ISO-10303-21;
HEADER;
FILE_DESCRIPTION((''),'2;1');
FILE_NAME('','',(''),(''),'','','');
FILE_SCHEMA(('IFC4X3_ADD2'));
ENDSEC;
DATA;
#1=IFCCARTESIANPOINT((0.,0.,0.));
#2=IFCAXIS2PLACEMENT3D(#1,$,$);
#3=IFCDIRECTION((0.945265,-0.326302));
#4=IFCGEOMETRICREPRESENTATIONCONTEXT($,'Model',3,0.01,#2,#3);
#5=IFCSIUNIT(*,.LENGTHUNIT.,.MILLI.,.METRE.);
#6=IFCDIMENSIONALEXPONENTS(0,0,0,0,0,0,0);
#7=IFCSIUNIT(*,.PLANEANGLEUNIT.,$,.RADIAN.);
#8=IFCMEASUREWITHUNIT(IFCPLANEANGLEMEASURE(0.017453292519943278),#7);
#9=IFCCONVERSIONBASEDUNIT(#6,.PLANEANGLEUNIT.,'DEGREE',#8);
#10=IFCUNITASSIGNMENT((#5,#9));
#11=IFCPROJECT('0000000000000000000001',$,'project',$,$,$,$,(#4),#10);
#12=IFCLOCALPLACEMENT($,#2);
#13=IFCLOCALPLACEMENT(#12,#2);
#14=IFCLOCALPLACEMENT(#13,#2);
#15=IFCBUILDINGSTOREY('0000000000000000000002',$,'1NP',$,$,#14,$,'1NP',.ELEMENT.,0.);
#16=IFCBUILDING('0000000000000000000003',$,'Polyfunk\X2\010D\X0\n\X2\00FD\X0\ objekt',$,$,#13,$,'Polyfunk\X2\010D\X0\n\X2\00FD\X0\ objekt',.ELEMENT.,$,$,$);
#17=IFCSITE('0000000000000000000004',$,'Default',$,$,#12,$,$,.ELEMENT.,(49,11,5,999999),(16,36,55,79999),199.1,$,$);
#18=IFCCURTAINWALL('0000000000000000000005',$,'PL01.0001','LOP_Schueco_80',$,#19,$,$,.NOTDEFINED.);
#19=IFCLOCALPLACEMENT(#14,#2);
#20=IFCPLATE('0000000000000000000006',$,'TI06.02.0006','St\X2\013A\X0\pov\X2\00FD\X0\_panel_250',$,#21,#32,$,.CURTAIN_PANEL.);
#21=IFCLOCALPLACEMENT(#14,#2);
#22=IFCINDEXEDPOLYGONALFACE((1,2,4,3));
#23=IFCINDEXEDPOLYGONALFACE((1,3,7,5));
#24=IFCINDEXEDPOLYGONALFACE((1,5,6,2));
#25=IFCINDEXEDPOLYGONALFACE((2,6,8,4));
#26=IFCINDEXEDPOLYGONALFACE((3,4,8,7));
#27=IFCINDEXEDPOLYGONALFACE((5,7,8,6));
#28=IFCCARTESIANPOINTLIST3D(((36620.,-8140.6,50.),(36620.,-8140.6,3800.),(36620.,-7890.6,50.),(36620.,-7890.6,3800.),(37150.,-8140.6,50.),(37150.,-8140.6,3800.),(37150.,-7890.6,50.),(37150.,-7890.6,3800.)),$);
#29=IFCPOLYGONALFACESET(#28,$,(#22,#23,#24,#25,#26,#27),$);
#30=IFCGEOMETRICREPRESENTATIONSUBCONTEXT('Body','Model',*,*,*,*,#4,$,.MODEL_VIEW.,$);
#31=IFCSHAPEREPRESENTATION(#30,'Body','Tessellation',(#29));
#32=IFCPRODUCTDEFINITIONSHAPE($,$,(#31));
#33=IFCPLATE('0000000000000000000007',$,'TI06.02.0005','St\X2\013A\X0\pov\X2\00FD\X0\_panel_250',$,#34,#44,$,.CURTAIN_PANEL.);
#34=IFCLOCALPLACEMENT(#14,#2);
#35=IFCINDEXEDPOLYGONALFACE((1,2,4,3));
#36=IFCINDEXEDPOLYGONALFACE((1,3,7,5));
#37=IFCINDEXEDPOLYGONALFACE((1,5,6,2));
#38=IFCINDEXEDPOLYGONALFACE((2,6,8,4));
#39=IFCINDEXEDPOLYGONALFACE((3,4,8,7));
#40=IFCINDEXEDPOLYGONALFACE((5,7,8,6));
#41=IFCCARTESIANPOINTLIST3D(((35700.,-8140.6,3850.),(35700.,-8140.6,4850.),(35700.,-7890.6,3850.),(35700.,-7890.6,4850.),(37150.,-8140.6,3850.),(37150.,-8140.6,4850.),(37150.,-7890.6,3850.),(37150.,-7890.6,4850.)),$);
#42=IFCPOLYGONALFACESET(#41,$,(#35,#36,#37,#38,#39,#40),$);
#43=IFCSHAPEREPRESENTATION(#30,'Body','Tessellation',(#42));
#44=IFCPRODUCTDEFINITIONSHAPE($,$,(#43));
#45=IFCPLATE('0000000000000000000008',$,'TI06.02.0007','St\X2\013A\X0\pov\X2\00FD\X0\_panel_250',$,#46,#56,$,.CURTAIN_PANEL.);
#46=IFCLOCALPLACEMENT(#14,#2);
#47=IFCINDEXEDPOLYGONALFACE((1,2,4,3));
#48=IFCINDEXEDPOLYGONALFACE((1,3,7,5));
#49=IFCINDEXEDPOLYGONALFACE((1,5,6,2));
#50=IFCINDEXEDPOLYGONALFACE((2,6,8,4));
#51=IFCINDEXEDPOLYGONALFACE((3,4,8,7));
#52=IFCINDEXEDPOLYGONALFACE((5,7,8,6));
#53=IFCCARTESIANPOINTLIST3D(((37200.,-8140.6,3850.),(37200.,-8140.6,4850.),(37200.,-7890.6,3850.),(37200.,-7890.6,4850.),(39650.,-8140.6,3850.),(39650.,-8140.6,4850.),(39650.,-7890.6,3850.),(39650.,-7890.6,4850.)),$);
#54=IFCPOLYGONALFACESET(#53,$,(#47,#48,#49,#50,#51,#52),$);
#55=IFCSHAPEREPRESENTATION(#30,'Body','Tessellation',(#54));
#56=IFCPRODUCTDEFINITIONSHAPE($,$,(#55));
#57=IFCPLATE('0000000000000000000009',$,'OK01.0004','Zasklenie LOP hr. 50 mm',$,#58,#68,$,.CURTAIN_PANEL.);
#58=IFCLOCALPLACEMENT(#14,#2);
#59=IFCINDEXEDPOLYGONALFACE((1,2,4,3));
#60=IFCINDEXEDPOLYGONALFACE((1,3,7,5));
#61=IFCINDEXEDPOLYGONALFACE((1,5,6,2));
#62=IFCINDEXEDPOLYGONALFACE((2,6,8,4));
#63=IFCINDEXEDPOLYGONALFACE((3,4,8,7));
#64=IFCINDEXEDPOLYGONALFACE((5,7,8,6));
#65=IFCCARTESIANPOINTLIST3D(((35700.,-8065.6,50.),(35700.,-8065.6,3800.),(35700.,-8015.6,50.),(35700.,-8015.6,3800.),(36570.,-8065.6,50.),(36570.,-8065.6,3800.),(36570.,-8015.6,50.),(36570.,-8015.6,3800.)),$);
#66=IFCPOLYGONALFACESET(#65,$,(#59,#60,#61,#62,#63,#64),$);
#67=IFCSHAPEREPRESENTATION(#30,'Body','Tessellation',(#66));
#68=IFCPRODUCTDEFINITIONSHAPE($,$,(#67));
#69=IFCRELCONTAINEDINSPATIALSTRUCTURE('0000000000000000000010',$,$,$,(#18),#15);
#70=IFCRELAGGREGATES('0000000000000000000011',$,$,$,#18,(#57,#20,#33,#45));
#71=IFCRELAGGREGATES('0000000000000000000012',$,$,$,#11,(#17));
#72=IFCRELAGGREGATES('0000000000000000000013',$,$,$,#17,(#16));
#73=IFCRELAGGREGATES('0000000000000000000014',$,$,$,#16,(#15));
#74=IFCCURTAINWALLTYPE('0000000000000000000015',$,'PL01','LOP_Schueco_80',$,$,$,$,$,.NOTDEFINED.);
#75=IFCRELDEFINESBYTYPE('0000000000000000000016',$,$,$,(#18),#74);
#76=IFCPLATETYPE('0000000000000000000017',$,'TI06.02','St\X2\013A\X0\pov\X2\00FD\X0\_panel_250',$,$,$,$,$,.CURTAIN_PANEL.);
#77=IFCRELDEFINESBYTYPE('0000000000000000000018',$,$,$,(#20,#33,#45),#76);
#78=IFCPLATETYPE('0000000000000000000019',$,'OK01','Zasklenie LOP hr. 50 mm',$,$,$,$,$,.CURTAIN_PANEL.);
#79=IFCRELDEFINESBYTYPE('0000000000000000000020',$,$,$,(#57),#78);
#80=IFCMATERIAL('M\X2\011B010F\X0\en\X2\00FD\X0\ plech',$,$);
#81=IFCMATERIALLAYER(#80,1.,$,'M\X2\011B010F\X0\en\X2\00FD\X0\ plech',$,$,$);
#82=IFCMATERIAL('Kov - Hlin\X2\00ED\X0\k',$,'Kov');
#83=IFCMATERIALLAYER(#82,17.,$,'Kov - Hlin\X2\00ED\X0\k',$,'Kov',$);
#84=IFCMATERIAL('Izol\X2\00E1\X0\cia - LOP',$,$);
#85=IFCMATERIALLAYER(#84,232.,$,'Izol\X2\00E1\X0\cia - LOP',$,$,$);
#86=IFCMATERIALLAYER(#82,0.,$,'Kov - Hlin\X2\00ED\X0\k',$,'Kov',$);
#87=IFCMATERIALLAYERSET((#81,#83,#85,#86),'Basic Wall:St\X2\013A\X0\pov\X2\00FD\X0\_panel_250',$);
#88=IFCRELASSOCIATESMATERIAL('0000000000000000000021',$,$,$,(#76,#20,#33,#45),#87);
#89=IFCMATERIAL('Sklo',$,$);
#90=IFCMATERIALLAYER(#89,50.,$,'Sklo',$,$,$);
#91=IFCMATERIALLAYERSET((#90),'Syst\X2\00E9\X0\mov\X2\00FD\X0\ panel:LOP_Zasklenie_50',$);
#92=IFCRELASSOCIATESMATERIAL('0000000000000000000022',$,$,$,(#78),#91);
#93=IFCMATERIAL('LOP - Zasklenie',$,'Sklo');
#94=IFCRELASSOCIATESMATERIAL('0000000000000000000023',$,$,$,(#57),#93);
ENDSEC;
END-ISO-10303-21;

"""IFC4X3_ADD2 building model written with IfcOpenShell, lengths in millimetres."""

from ifc_helpers import new_model, entity, si_unit, converted_unit, direction, frame, frame_2d, origin, place, context, subcontext, project, spatial, rectangle, extrude, source, transform, mapped, material, layer, layer_set, layer_usage, type_object, type_shapes, element, aggregate, save


model = new_model("IFC4X3_ADD2")

# Units and contexts
model_context = context("Model", 3, precision=0.01, world=origin(), true_north=direction((0.945265, -0.326302)))
body_context = subcontext(model_context, "Body", "Model", "MODEL_VIEW")
ifc_project = project(units=[si_unit("LENGTHUNIT", "METRE", prefix="MILLI"), converted_unit("PLANEANGLEUNIT", "DEGREE", entity("IfcPlaneAngleMeasure", 0.017453292519943278), si_unit("PLANEANGLEUNIT", "RADIAN"), dimensions=[0, 0, 0, 0, 0, 0, 0])], contexts=[model_context])

# Site, building, storey
site_placement = place(None, origin())
site = spatial("IfcSite", under=ifc_project, at=site_placement, Name="Default", CompositionType="ELEMENT", RefLatitude=(49, 11, 5, 999999), RefLongitude=(16, 36, 55, 79999), RefElevation=199.1)
building_placement = place(site_placement, origin())
building = spatial("IfcBuilding", under=site, at=building_placement, Name="Polyfunkčný objekt", LongName="Polyfunkčný objekt", CompositionType="ELEMENT")
storey_placement = place(building_placement, origin())
storey = spatial("IfcBuildingStorey", under=building, at=storey_placement, Name="1NP", LongName="1NP", CompositionType="ELEMENT", Elevation=0.0)

# Curtain wall, plates
curtain_wall_type = type_object("IfcCurtainWallType", Name="PL01", Description="LOP_Schueco_80", PredefinedType="NOTDEFINED")
curtain_wall_placement = place(storey_placement, origin())
curtain_wall = element("IfcCurtainWall", 1, at=curtain_wall_placement, inside=storey, type_object=curtain_wall_type, Name="PL01.0001", Description="LOP_Schueco_80", PredefinedType="NOTDEFINED")
ifc_material_1 = material(Name="Měďený plech")
ifc_layer_1 = layer(ifc_material_1, 1.0, Name="Měďený plech")
ifc_material_2 = material(Name="Kov - Hliník", Category="Kov")
ifc_layer_2 = layer(ifc_material_2, 17.0, Name="Kov - Hliník", Category="Kov")
ifc_material_3 = material(Name="Izolácia - LOP")
ifc_layer_3 = layer(ifc_material_3, 232.0, Name="Izolácia - LOP")
ifc_layer_4 = layer(ifc_material_2, 0.0, Name="Kov - Hliník", Category="Kov")
ifc_layer_set_1 = layer_set([ifc_layer_1, ifc_layer_2, ifc_layer_3, ifc_layer_4], Name="Basic Wall:Stĺpový_panel_250")
ifc_layer_usage_1 = layer_usage(ifc_layer_set_1, "AXIS2", "POSITIVE", -125.0)
plate_type_1 = type_object("IfcPlateType", Name="TI06.02", Description="Stĺpový_panel_250", PredefinedType="CURTAIN_PANEL", material=ifc_layer_set_1)
plate_1_placement = place(storey_placement, frame((36620.0, -8015.6, 50.0)))
plate_1 = element("IfcPlate", 2, at=plate_1_placement, type_object=plate_type_1, material=ifc_layer_usage_1, Name="TI06.02.0006", Description="Stĺpový_panel_250", PredefinedType="CURTAIN_PANEL", context=body_context, shape_type="SweptSolid", body=[
    extrude(rectangle(XDim=250.0, YDim=530.0, at=frame_2d((0.0, 0.0), x_axis=(1.0, 0.0))), frame((265.0, 0.0, 0.0), z_axis=(0.0, 0.0, 1.0), x_axis=(0.0, 1.0, 0.0)), (0.0, 0.0, 1.0), 3750.0),
])
ifc_layer_usage_2 = layer_usage(ifc_layer_set_1, "AXIS2", "POSITIVE", -125.0)
plate_2_placement = place(storey_placement, frame((35700.0, -8015.6, 3850.0)))
plate_2 = element("IfcPlate", 3, at=plate_2_placement, type_object=plate_type_1, material=ifc_layer_usage_2, Name="TI06.02.0005", Description="Stĺpový_panel_250", PredefinedType="CURTAIN_PANEL", context=body_context, shape_type="SweptSolid", body=[
    extrude(rectangle(XDim=250.0, YDim=1450.0, at=frame_2d((0.0, 0.0), x_axis=(1.0, 0.0))), frame((725.0, 0.0, 0.0), z_axis=(0.0, 0.0, 1.0), x_axis=(0.0, 1.0, 0.0)), (0.0, 0.0, 1.0), 1000.0),
])
ifc_layer_usage_3 = layer_usage(ifc_layer_set_1, "AXIS2", "POSITIVE", -125.0)
plate_3_placement = place(storey_placement, frame((37200.0, -8015.6, 3850.0)))
plate_3 = element("IfcPlate", 4, at=plate_3_placement, type_object=plate_type_1, material=ifc_layer_usage_3, Name="TI06.02.0007", Description="Stĺpový_panel_250", PredefinedType="CURTAIN_PANEL", context=body_context, shape_type="SweptSolid", body=[
    extrude(rectangle(XDim=250.0, YDim=2450.0, at=frame_2d((0.0, 0.0), x_axis=(1.0, 0.0))), frame((1225.0, 0.0, 0.0), z_axis=(0.0, 0.0, 1.0), x_axis=(0.0, 1.0, 0.0)), (0.0, 0.0, 1.0), 1000.0),
])
ifc_material_4 = material(Name="LOP - Zasklenie", Category="Sklo")
ifc_material_5 = material(Name="Sklo")
ifc_layer_5 = layer(ifc_material_5, 50.0, Name="Sklo")
ifc_layer_set_2 = layer_set([ifc_layer_5], Name="Systémový panel:LOP_Zasklenie_50")
plate_type_2 = type_object("IfcPlateType", Name="OK01", Description="Zasklenie LOP hr. 50 mm", PredefinedType="CURTAIN_PANEL", material=ifc_layer_set_2)
shared_shape_1 = source(origin(), body_context, "Body", "SweptSolid", [
    extrude(rectangle(XDim=3750.0, YDim=870.0, at=frame_2d((-331.2, 0.0), x_axis=(1.0, 0.0))), frame((0.0, -50.0, 2206.2), z_axis=(0.0, 1.0, 0.0), x_axis=(0.0, 0.0, 1.0)), (0.0, 0.0, 1.0), 50.0),
])
type_shapes(plate_type_2, [shared_shape_1])
plate_4_placement = place(curtain_wall_placement, frame((36135.0, -8015.6, 50.0)))
plate_4 = element("IfcPlate", 5, at=plate_4_placement, type_object=plate_type_2, material=ifc_material_4, Name="OK01.0004", Description="Zasklenie LOP hr. 50 mm", PredefinedType="CURTAIN_PANEL", context=body_context, shape_type="MappedRepresentation", body=[
    mapped(shared_shape_1, transform((0.0, 0.0, 0.0), scale=1.0)),
])
aggregate(curtain_wall, [plate_4, plate_1, plate_2, plate_3])

save(model, "model.ifc")
